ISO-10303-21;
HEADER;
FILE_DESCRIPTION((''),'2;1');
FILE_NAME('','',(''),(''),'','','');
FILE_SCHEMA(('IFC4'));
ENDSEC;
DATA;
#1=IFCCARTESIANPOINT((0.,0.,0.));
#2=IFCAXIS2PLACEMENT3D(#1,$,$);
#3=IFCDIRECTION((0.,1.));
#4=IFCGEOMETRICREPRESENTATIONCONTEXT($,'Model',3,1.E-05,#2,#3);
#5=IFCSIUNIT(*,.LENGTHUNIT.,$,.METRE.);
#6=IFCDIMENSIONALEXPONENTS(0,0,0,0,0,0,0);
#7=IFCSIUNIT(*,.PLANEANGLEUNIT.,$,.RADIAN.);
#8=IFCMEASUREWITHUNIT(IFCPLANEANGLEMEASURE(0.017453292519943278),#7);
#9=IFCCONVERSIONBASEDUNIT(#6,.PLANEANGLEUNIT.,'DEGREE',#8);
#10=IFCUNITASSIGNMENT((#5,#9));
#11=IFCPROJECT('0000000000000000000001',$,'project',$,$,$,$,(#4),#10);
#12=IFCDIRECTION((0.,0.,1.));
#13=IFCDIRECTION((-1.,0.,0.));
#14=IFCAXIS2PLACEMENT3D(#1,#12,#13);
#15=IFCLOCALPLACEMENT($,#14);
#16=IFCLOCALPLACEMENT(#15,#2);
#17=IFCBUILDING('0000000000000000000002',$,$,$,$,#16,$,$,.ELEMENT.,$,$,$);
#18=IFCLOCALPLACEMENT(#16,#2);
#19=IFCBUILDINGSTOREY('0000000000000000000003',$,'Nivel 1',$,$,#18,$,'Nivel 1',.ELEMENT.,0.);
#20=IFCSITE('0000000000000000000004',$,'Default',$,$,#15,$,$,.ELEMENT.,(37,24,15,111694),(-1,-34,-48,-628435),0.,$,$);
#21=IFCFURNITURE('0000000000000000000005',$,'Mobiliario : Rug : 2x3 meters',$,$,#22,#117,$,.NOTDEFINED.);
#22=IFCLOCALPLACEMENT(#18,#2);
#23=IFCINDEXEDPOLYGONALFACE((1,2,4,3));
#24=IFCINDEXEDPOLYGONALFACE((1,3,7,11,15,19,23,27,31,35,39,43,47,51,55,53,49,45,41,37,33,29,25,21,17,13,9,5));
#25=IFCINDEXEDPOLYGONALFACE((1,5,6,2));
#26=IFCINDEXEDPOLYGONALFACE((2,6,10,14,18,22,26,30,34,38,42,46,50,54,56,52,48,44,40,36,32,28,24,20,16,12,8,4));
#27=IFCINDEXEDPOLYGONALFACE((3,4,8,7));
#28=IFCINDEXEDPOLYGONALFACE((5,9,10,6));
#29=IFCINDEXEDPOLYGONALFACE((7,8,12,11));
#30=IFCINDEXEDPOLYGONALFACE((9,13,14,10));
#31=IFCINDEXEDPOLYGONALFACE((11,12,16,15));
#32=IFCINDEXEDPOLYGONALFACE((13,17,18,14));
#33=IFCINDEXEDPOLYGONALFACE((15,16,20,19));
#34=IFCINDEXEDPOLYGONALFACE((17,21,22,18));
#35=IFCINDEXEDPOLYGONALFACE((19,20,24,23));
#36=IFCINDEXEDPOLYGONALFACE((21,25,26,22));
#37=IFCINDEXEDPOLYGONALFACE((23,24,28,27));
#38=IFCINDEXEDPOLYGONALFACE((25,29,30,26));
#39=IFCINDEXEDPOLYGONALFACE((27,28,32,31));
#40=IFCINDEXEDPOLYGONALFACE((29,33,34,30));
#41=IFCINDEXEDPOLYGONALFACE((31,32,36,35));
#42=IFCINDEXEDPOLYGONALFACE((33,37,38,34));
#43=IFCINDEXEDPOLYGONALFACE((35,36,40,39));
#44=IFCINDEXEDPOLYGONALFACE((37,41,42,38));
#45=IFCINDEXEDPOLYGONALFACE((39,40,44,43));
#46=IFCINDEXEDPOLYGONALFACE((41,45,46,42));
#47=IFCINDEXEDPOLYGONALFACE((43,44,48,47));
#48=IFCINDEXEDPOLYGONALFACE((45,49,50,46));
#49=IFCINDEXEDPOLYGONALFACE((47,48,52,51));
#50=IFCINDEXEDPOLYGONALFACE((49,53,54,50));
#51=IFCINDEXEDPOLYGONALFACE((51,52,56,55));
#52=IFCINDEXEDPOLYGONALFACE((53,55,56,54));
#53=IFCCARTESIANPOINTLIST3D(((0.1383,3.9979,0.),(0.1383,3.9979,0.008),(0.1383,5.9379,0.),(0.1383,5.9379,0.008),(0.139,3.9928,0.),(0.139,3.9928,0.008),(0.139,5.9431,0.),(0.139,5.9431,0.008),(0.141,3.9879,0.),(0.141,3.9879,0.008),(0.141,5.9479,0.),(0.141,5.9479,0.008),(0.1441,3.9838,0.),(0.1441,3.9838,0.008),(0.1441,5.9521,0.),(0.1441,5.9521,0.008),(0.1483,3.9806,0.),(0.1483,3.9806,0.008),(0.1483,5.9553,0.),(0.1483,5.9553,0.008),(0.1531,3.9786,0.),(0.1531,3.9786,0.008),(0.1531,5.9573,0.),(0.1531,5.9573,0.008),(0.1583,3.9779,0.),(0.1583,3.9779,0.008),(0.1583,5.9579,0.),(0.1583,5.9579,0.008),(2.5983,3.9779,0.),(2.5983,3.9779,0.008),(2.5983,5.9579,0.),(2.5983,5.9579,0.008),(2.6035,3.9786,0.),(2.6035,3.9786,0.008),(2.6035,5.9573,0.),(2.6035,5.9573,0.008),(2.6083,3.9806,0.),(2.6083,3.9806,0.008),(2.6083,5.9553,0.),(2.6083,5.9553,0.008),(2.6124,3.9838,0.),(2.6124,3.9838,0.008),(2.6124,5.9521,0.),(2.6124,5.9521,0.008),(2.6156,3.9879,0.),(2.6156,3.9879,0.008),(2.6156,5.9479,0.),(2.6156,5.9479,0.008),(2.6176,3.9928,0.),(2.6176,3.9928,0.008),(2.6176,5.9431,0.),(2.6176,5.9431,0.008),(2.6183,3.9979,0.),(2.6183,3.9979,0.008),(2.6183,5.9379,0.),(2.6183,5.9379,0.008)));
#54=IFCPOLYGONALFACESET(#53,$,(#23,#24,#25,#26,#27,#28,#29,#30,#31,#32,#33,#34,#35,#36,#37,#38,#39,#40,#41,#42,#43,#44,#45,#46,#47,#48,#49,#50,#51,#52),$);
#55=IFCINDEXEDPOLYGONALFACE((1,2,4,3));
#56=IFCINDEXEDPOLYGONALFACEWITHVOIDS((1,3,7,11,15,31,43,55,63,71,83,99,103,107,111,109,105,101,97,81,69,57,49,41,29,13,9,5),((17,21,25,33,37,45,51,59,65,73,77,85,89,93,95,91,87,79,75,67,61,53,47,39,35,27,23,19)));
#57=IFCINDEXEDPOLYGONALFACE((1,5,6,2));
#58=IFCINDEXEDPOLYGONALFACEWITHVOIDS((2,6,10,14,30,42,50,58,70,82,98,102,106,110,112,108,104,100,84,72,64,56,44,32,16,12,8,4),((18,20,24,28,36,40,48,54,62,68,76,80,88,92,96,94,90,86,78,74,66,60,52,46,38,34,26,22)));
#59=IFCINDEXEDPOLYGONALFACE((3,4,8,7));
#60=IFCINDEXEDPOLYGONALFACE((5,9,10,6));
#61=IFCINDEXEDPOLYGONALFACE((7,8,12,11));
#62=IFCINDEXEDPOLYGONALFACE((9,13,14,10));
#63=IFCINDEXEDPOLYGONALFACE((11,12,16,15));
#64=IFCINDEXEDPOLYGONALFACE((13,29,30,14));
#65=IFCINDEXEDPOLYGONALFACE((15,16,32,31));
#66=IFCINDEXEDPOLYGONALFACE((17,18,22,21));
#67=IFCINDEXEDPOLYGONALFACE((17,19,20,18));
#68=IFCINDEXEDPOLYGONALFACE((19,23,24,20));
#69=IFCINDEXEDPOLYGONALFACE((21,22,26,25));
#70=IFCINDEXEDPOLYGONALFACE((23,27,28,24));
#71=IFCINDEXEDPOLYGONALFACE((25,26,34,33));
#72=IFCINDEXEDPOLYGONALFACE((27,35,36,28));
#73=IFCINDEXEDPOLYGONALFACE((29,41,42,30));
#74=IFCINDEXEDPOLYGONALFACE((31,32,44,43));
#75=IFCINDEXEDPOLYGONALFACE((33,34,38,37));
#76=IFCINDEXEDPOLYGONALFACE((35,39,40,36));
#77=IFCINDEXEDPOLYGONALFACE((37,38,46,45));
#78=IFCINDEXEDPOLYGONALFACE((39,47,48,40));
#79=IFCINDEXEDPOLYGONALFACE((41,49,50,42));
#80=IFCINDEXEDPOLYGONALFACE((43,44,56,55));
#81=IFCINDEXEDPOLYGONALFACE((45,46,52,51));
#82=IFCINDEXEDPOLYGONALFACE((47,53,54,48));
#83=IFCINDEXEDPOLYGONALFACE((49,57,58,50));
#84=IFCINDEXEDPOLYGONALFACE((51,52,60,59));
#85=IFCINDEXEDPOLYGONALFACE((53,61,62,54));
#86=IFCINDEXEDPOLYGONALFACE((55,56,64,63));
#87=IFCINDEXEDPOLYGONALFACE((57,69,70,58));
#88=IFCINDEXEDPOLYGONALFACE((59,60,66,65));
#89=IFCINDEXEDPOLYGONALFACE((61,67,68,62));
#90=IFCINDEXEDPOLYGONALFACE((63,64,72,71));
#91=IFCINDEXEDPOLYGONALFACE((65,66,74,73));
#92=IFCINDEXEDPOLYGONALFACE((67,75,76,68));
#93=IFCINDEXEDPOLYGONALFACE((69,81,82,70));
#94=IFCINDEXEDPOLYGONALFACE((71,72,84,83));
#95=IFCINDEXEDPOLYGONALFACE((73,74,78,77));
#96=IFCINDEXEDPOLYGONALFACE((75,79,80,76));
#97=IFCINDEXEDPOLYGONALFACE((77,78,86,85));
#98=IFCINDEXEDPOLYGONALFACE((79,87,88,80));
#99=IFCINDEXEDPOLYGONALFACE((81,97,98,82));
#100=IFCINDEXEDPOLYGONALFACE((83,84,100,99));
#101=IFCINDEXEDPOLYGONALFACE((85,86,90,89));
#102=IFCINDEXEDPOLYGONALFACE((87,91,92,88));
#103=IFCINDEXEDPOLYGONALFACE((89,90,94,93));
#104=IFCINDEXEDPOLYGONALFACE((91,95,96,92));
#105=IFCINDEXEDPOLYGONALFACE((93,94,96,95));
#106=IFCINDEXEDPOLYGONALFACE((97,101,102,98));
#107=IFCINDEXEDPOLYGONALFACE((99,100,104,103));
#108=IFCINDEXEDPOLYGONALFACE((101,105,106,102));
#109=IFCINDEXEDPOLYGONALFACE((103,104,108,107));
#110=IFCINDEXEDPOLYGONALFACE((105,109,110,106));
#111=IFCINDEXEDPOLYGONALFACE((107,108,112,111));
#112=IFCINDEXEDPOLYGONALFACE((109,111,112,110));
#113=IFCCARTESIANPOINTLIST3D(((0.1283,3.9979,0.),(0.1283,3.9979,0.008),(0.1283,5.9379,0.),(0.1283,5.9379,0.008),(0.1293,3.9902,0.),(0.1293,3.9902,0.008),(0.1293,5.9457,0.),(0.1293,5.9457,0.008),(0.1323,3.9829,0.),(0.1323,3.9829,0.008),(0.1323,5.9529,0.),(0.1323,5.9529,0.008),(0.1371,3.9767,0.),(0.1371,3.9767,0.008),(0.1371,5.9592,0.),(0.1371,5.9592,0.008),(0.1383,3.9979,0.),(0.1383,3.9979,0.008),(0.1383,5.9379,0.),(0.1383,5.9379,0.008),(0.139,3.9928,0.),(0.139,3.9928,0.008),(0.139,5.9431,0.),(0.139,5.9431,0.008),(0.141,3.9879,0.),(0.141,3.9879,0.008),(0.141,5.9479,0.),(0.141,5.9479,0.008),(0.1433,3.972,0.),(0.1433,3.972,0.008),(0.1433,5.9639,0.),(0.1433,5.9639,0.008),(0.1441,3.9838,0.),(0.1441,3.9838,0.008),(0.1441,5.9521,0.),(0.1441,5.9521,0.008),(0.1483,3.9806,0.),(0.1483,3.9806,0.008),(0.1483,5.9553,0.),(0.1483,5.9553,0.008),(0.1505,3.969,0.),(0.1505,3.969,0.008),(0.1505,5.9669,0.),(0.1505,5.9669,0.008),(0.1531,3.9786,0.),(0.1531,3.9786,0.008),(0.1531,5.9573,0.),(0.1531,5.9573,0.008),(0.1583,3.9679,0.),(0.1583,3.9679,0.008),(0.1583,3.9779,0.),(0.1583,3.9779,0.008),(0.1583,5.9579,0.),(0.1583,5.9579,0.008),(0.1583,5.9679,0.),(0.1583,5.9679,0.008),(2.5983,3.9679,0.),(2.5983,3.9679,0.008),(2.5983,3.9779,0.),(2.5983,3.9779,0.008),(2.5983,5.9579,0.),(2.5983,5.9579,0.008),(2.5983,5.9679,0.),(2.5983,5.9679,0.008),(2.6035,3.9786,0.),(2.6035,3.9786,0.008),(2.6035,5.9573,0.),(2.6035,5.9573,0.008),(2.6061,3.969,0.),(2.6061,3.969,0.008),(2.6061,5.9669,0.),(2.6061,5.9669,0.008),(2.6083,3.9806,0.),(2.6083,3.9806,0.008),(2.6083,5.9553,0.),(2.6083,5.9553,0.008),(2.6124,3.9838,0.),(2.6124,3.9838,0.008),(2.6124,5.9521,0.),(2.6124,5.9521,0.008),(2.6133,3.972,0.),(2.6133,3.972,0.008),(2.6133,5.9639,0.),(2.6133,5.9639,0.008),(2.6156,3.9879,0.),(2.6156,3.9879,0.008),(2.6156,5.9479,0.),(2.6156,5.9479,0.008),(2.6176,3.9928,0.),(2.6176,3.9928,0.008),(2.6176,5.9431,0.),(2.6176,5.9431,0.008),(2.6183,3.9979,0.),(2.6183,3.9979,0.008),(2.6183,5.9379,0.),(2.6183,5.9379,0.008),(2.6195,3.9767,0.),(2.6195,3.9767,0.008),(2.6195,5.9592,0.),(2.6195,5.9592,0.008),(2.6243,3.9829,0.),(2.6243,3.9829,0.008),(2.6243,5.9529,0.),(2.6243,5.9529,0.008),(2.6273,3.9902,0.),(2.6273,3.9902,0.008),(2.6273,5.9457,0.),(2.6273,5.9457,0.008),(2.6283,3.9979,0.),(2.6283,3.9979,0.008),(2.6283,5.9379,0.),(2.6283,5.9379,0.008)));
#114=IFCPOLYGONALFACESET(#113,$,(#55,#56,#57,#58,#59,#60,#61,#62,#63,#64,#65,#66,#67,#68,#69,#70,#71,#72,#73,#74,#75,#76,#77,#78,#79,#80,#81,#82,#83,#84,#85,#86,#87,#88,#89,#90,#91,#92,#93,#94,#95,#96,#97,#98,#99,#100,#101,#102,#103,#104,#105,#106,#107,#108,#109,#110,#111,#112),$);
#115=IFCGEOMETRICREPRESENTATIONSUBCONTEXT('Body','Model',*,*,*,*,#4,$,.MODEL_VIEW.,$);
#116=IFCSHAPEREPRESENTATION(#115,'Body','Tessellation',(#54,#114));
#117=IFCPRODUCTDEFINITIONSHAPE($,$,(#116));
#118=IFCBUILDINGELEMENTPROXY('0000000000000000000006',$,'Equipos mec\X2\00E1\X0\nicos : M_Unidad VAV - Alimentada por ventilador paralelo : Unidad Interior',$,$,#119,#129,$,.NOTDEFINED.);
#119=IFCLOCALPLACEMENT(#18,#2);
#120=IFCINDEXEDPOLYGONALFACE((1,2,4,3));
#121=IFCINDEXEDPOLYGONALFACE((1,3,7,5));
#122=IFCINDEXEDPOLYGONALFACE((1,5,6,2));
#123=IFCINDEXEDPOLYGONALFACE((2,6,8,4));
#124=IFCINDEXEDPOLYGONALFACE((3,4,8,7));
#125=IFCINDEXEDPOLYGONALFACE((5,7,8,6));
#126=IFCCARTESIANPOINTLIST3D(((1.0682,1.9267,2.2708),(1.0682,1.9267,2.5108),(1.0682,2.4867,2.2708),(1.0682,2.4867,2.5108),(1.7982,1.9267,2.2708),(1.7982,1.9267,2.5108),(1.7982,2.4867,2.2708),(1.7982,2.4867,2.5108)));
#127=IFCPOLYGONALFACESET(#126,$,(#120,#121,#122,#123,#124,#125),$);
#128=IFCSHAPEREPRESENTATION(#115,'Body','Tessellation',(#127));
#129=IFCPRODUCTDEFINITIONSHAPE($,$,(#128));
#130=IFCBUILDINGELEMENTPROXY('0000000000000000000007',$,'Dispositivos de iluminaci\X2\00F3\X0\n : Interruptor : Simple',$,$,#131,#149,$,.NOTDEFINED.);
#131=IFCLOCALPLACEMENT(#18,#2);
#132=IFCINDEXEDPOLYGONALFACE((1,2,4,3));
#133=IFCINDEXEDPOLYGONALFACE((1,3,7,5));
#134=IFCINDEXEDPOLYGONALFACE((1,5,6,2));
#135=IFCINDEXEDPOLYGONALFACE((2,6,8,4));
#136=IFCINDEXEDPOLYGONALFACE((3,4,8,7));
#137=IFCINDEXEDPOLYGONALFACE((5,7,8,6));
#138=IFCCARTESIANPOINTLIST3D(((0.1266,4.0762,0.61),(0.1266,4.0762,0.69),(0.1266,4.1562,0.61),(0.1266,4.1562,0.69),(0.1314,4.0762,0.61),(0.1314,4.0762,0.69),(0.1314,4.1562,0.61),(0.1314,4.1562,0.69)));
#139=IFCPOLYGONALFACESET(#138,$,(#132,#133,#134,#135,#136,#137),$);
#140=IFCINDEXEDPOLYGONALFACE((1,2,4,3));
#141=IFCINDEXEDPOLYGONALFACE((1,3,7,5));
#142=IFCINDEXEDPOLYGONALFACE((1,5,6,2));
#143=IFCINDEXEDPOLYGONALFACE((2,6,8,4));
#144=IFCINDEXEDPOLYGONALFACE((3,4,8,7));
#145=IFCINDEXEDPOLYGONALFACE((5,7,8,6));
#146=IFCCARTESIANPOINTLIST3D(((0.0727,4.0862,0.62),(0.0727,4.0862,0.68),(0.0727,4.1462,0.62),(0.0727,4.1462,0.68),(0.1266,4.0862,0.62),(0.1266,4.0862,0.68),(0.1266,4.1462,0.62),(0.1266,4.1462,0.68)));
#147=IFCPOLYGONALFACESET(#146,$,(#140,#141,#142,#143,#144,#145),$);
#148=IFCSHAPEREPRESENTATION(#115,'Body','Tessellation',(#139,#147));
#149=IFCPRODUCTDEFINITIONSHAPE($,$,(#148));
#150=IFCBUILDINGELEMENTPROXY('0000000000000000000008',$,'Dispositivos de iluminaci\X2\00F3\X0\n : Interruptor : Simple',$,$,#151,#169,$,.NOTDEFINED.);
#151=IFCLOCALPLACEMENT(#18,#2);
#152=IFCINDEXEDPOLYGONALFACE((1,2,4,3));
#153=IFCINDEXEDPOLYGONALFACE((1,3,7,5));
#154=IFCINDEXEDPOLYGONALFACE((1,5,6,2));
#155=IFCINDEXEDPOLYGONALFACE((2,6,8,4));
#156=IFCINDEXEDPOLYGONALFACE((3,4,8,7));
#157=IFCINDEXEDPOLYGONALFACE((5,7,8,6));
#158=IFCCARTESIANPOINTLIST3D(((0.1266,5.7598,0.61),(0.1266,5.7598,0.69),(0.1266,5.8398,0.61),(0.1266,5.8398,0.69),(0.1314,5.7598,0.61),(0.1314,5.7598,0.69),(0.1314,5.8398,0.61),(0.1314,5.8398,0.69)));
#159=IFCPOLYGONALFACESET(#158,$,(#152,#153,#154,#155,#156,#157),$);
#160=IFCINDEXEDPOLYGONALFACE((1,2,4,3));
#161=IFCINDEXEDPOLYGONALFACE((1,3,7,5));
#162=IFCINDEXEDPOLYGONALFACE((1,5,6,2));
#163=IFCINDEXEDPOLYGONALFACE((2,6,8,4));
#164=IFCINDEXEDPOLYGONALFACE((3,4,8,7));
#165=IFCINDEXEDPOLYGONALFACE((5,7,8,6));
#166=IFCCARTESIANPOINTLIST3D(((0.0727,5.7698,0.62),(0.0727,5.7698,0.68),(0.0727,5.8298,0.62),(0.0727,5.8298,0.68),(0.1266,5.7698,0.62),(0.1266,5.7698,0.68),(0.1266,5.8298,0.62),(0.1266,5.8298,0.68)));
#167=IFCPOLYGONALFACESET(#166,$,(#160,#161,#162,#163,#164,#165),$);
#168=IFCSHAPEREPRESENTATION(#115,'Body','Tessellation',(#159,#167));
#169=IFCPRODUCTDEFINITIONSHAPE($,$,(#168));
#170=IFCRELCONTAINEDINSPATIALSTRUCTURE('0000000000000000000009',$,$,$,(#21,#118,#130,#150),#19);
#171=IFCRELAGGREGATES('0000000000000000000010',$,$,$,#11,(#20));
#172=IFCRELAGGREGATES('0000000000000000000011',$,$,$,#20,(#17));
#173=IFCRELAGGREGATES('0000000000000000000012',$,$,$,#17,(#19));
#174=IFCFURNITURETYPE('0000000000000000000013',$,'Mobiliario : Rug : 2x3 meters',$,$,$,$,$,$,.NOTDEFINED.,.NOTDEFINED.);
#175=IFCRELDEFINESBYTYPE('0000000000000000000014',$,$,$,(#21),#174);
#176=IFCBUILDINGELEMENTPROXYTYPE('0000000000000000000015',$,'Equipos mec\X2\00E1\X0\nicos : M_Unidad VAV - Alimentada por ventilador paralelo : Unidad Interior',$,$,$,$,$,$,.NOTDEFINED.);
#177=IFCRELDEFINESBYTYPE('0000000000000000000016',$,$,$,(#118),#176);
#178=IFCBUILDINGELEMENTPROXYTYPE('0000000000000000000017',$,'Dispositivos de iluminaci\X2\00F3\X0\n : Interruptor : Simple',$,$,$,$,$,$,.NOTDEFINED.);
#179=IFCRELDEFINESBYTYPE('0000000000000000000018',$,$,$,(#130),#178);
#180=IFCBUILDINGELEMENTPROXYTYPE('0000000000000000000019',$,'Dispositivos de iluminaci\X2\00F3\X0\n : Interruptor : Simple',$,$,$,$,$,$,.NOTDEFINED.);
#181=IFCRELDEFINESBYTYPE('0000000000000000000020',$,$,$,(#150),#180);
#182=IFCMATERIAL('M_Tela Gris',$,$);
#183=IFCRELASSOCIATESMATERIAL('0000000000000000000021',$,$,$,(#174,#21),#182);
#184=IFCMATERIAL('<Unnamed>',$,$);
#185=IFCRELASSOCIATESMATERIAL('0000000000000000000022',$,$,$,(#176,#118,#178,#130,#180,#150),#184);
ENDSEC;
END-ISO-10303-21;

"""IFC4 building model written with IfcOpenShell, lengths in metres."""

from ifc_helpers import new_model, entity, si_unit, converted_unit, direction, frame, origin, place, context, subcontext, project, spatial, line, arc, indexed_curve, outline, extrude, source, transform, mapped, material, type_object, type_shapes, element, save


model = new_model("IFC4")

# Units and contexts
model_context = context("Model", 3, precision=1e-05, world=origin(), true_north=direction((0.0, 1.0)))
body_context = subcontext(model_context, "Body", "Model", "MODEL_VIEW")
ifc_project = project(units=[si_unit("LENGTHUNIT", "METRE"), converted_unit("PLANEANGLEUNIT", "DEGREE", entity("IfcPlaneAngleMeasure", 0.017453292519943278), si_unit("PLANEANGLEUNIT", "RADIAN"), dimensions=[0, 0, 0, 0, 0, 0, 0])], contexts=[model_context])

# Site, building, storey
site_placement = place(None, frame((0.0, 0.0, 0.0), z_axis=(0.0, 0.0, 1.0), x_axis=(-1.0, 0.0, 0.0)))
site = spatial("IfcSite", under=ifc_project, at=site_placement, Name="Default", CompositionType="ELEMENT", RefLatitude=(37, 24, 15, 111694), RefLongitude=(-1, -34, -48, -628435), RefElevation=0.0)
building_placement = place(site_placement, origin())
building = spatial("IfcBuilding", under=site, at=building_placement, CompositionType="ELEMENT")
storey_placement = place(building_placement, origin())
storey = spatial("IfcBuildingStorey", under=building, at=storey_placement, Name="Nivel 1", LongName="Nivel 1", CompositionType="ELEMENT", Elevation=0.0)

# Shared definitions
ifc_material_1 = material(Name="<Unnamed>")

# Furniture
ifc_material_2 = material(Name="M_Tela Gris")
furniture_type_1 = type_object("IfcFurnitureType", Name="Mobiliario : Rug : 2x3 meters", AssemblyPlace="NOTDEFINED", PredefinedType="NOTDEFINED", material=ifc_material_2)
shared_shape_1 = source(origin(), body_context, "Body", "SweptSolid", [
    extrude(outline(indexed_curve([(-0.97, -1.24), (0.97, -1.24), (0.9841, -1.2341), (0.99, -1.22), (0.99, 1.22), (0.9841, 1.2341), (0.97, 1.24), (-0.97, 1.24), (-0.9841, 1.2341), (-0.99, 1.22), (-0.99, -1.22), (-0.9841, -1.2341)], segments=[line(1, 2), arc(2, 3, 4), line(4, 5), arc(5, 6, 7), line(7, 8), arc(8, 9, 10), line(10, 11), arc(11, 12, 1)], self_intersect=False)), frame((0.0, 0.0, 0.0), z_axis=(0.0, 0.0, 1.0), x_axis=(-1.0, 0.0, 0.0)), (0.0, 0.0, 1.0), 0.008),
    extrude(outline(indexed_curve([(-0.97, -1.25), (0.97, -1.25), (0.9912, -1.2412), (1.0, -1.22), (1.0, 1.22), (0.9912, 1.2412), (0.97, 1.25), (-0.97, 1.25), (-0.9912, 1.2412), (-1.0, 1.22), (-1.0, -1.22), (-0.9912, -1.2412)], segments=[line(1, 2), arc(2, 3, 4), line(4, 5), arc(5, 6, 7), line(7, 8), arc(8, 9, 10), line(10, 11), arc(11, 12, 1)], self_intersect=False), holes=[indexed_curve([(-0.97, -1.24), (-0.9841, -1.2341), (-0.99, -1.22), (-0.99, 1.22), (-0.9841, 1.2341), (-0.97, 1.24), (0.97, 1.24), (0.9841, 1.2341), (0.99, 1.22), (0.99, -1.22), (0.9841, -1.2341), (0.97, -1.24)], segments=[arc(1, 2, 3), line(3, 4), arc(4, 5, 6), line(6, 7), arc(7, 8, 9), line(9, 10), arc(10, 11, 12), line(12, 1)], self_intersect=False)]), frame((0.0, 0.0, 0.0), z_axis=(0.0, 0.0, 1.0), x_axis=(-1.0, 0.0, 0.0)), (0.0, 0.0, 1.0), 0.008),
])
type_shapes(furniture_type_1, [shared_shape_1])
furniture_1_placement = place(storey_placement, frame((1.3783, 4.9679, 0.0), z_axis=(0.0, 0.0, 1.0), x_axis=(0.0, 1.0, 0.0)))
element("IfcFurniture", 1, at=furniture_1_placement, inside=storey, type_object=furniture_type_1, material=ifc_material_2, Name="Mobiliario : Rug : 2x3 meters", PredefinedType="NOTDEFINED", context=body_context, shape_type="MappedRepresentation", body=[
    mapped(shared_shape_1, transform((0.0, 0.0, 0.0), scale=1.0)),
])

# Building element proxies
building_element_proxy_type_1 = type_object("IfcBuildingElementProxyType", Name="Equipos mecánicos : M_Unidad VAV - Alimentada por ventilador paralelo : Unidad Interior", PredefinedType="NOTDEFINED", material=ifc_material_1)
shared_shape_2 = source(origin(), body_context, "Body", "SweptSolid", [
    extrude(outline(indexed_curve([(-0.28, -0.365), (0.28, -0.365), (0.28, 0.365), (-0.28, 0.365), (-0.28, -0.365)], self_intersect=False)), frame((0.0, 0.0, -0.12), z_axis=(0.0, 0.0, 1.0), x_axis=(-1.0, 0.0, 0.0)), (0.0, 0.0, 1.0), 0.24),
])
type_shapes(building_element_proxy_type_1, [shared_shape_2])
proxy_1_placement = place(storey_placement, frame((1.4332, 2.2067, 2.3908), z_axis=(0.0, 0.0, 1.0), x_axis=(0.0, 1.0, 0.0)))
element("IfcBuildingElementProxy", 2, at=proxy_1_placement, inside=storey, type_object=building_element_proxy_type_1, material=ifc_material_1, Name="Equipos mecánicos : M_Unidad VAV - Alimentada por ventilador paralelo : Unidad Interior", PredefinedType="NOTDEFINED", context=body_context, shape_type="MappedRepresentation", body=[
    mapped(shared_shape_2, transform((0.0, 0.0, 0.0), scale=1.0)),
])
building_element_proxy_type_2 = type_object("IfcBuildingElementProxyType", Name="Dispositivos de iluminación : Interruptor : Simple", PredefinedType="NOTDEFINED", material=ifc_material_1)
shared_shape_3 = source(origin(), body_context, "Body", "SweptSolid", [
    extrude(outline(indexed_curve([(-0.04, -0.04), (0.04, -0.04), (0.04, 0.04), (-0.04, 0.04), (-0.04, -0.04)], self_intersect=False)), frame((0.0, 0.0, 0.0), z_axis=(0.0, 0.0, 1.0), x_axis=(0.0, -1.0, 0.0)), (0.0, 0.0, 1.0), 0.0048),
    extrude(outline(indexed_curve([(-0.03, -0.03), (0.03, -0.03), (0.03, 0.03), (-0.03, 0.03), (-0.03, -0.03)], self_intersect=False)), frame((0.0, 0.0, -0.054), z_axis=(0.0, 0.0, 1.0), x_axis=(-1.0, 0.0, 0.0)), (0.0, 0.0, 1.0), 0.054),
])
type_shapes(building_element_proxy_type_2, [shared_shape_3])
proxy_2_placement = place(storey_placement, frame((0.1266, 4.1162, 0.65), z_axis=(1.0, 0.0, 0.0), x_axis=(0.0, 1.0, 0.0)))
element("IfcBuildingElementProxy", 3, at=proxy_2_placement, inside=storey, type_object=building_element_proxy_type_2, material=ifc_material_1, Name="Dispositivos de iluminación : Interruptor : Simple", PredefinedType="NOTDEFINED", context=body_context, shape_type="MappedRepresentation", body=[
    mapped(shared_shape_3, transform((0.0, 0.0, 0.0), scale=1.0)),
])
building_element_proxy_type_3 = type_object("IfcBuildingElementProxyType", Name="Dispositivos de iluminación : Interruptor : Simple", PredefinedType="NOTDEFINED", material=ifc_material_1)
shared_shape_4 = source(origin(), body_context, "Body", "SweptSolid", [
    extrude(outline(indexed_curve([(-0.04, -0.04), (0.04, -0.04), (0.04, 0.04), (-0.04, 0.04), (-0.04, -0.04)], self_intersect=False)), frame((0.0, 0.0, 0.0), z_axis=(0.0, 0.0, 1.0), x_axis=(0.0, -1.0, 0.0)), (0.0, 0.0, 1.0), 0.0048),
    extrude(outline(indexed_curve([(-0.03, -0.03), (0.03, -0.03), (0.03, 0.03), (-0.03, 0.03), (-0.03, -0.03)], self_intersect=False)), frame((0.0, 0.0, -0.054), z_axis=(0.0, 0.0, 1.0), x_axis=(-1.0, 0.0, 0.0)), (0.0, 0.0, 1.0), 0.054),
])
type_shapes(building_element_proxy_type_3, [shared_shape_4])
proxy_3_placement = place(storey_placement, frame((0.1266, 5.7998, 0.65), z_axis=(1.0, 0.0, 0.0), x_axis=(0.0, 1.0, 0.0)))
element("IfcBuildingElementProxy", 4, at=proxy_3_placement, inside=storey, type_object=building_element_proxy_type_3, material=ifc_material_1, Name="Dispositivos de iluminación : Interruptor : Simple", PredefinedType="NOTDEFINED", context=body_context, shape_type="MappedRepresentation", body=[
    mapped(shared_shape_4, transform((0.0, 0.0, 0.0), scale=1.0)),
])

save(model, "model.ifc")
